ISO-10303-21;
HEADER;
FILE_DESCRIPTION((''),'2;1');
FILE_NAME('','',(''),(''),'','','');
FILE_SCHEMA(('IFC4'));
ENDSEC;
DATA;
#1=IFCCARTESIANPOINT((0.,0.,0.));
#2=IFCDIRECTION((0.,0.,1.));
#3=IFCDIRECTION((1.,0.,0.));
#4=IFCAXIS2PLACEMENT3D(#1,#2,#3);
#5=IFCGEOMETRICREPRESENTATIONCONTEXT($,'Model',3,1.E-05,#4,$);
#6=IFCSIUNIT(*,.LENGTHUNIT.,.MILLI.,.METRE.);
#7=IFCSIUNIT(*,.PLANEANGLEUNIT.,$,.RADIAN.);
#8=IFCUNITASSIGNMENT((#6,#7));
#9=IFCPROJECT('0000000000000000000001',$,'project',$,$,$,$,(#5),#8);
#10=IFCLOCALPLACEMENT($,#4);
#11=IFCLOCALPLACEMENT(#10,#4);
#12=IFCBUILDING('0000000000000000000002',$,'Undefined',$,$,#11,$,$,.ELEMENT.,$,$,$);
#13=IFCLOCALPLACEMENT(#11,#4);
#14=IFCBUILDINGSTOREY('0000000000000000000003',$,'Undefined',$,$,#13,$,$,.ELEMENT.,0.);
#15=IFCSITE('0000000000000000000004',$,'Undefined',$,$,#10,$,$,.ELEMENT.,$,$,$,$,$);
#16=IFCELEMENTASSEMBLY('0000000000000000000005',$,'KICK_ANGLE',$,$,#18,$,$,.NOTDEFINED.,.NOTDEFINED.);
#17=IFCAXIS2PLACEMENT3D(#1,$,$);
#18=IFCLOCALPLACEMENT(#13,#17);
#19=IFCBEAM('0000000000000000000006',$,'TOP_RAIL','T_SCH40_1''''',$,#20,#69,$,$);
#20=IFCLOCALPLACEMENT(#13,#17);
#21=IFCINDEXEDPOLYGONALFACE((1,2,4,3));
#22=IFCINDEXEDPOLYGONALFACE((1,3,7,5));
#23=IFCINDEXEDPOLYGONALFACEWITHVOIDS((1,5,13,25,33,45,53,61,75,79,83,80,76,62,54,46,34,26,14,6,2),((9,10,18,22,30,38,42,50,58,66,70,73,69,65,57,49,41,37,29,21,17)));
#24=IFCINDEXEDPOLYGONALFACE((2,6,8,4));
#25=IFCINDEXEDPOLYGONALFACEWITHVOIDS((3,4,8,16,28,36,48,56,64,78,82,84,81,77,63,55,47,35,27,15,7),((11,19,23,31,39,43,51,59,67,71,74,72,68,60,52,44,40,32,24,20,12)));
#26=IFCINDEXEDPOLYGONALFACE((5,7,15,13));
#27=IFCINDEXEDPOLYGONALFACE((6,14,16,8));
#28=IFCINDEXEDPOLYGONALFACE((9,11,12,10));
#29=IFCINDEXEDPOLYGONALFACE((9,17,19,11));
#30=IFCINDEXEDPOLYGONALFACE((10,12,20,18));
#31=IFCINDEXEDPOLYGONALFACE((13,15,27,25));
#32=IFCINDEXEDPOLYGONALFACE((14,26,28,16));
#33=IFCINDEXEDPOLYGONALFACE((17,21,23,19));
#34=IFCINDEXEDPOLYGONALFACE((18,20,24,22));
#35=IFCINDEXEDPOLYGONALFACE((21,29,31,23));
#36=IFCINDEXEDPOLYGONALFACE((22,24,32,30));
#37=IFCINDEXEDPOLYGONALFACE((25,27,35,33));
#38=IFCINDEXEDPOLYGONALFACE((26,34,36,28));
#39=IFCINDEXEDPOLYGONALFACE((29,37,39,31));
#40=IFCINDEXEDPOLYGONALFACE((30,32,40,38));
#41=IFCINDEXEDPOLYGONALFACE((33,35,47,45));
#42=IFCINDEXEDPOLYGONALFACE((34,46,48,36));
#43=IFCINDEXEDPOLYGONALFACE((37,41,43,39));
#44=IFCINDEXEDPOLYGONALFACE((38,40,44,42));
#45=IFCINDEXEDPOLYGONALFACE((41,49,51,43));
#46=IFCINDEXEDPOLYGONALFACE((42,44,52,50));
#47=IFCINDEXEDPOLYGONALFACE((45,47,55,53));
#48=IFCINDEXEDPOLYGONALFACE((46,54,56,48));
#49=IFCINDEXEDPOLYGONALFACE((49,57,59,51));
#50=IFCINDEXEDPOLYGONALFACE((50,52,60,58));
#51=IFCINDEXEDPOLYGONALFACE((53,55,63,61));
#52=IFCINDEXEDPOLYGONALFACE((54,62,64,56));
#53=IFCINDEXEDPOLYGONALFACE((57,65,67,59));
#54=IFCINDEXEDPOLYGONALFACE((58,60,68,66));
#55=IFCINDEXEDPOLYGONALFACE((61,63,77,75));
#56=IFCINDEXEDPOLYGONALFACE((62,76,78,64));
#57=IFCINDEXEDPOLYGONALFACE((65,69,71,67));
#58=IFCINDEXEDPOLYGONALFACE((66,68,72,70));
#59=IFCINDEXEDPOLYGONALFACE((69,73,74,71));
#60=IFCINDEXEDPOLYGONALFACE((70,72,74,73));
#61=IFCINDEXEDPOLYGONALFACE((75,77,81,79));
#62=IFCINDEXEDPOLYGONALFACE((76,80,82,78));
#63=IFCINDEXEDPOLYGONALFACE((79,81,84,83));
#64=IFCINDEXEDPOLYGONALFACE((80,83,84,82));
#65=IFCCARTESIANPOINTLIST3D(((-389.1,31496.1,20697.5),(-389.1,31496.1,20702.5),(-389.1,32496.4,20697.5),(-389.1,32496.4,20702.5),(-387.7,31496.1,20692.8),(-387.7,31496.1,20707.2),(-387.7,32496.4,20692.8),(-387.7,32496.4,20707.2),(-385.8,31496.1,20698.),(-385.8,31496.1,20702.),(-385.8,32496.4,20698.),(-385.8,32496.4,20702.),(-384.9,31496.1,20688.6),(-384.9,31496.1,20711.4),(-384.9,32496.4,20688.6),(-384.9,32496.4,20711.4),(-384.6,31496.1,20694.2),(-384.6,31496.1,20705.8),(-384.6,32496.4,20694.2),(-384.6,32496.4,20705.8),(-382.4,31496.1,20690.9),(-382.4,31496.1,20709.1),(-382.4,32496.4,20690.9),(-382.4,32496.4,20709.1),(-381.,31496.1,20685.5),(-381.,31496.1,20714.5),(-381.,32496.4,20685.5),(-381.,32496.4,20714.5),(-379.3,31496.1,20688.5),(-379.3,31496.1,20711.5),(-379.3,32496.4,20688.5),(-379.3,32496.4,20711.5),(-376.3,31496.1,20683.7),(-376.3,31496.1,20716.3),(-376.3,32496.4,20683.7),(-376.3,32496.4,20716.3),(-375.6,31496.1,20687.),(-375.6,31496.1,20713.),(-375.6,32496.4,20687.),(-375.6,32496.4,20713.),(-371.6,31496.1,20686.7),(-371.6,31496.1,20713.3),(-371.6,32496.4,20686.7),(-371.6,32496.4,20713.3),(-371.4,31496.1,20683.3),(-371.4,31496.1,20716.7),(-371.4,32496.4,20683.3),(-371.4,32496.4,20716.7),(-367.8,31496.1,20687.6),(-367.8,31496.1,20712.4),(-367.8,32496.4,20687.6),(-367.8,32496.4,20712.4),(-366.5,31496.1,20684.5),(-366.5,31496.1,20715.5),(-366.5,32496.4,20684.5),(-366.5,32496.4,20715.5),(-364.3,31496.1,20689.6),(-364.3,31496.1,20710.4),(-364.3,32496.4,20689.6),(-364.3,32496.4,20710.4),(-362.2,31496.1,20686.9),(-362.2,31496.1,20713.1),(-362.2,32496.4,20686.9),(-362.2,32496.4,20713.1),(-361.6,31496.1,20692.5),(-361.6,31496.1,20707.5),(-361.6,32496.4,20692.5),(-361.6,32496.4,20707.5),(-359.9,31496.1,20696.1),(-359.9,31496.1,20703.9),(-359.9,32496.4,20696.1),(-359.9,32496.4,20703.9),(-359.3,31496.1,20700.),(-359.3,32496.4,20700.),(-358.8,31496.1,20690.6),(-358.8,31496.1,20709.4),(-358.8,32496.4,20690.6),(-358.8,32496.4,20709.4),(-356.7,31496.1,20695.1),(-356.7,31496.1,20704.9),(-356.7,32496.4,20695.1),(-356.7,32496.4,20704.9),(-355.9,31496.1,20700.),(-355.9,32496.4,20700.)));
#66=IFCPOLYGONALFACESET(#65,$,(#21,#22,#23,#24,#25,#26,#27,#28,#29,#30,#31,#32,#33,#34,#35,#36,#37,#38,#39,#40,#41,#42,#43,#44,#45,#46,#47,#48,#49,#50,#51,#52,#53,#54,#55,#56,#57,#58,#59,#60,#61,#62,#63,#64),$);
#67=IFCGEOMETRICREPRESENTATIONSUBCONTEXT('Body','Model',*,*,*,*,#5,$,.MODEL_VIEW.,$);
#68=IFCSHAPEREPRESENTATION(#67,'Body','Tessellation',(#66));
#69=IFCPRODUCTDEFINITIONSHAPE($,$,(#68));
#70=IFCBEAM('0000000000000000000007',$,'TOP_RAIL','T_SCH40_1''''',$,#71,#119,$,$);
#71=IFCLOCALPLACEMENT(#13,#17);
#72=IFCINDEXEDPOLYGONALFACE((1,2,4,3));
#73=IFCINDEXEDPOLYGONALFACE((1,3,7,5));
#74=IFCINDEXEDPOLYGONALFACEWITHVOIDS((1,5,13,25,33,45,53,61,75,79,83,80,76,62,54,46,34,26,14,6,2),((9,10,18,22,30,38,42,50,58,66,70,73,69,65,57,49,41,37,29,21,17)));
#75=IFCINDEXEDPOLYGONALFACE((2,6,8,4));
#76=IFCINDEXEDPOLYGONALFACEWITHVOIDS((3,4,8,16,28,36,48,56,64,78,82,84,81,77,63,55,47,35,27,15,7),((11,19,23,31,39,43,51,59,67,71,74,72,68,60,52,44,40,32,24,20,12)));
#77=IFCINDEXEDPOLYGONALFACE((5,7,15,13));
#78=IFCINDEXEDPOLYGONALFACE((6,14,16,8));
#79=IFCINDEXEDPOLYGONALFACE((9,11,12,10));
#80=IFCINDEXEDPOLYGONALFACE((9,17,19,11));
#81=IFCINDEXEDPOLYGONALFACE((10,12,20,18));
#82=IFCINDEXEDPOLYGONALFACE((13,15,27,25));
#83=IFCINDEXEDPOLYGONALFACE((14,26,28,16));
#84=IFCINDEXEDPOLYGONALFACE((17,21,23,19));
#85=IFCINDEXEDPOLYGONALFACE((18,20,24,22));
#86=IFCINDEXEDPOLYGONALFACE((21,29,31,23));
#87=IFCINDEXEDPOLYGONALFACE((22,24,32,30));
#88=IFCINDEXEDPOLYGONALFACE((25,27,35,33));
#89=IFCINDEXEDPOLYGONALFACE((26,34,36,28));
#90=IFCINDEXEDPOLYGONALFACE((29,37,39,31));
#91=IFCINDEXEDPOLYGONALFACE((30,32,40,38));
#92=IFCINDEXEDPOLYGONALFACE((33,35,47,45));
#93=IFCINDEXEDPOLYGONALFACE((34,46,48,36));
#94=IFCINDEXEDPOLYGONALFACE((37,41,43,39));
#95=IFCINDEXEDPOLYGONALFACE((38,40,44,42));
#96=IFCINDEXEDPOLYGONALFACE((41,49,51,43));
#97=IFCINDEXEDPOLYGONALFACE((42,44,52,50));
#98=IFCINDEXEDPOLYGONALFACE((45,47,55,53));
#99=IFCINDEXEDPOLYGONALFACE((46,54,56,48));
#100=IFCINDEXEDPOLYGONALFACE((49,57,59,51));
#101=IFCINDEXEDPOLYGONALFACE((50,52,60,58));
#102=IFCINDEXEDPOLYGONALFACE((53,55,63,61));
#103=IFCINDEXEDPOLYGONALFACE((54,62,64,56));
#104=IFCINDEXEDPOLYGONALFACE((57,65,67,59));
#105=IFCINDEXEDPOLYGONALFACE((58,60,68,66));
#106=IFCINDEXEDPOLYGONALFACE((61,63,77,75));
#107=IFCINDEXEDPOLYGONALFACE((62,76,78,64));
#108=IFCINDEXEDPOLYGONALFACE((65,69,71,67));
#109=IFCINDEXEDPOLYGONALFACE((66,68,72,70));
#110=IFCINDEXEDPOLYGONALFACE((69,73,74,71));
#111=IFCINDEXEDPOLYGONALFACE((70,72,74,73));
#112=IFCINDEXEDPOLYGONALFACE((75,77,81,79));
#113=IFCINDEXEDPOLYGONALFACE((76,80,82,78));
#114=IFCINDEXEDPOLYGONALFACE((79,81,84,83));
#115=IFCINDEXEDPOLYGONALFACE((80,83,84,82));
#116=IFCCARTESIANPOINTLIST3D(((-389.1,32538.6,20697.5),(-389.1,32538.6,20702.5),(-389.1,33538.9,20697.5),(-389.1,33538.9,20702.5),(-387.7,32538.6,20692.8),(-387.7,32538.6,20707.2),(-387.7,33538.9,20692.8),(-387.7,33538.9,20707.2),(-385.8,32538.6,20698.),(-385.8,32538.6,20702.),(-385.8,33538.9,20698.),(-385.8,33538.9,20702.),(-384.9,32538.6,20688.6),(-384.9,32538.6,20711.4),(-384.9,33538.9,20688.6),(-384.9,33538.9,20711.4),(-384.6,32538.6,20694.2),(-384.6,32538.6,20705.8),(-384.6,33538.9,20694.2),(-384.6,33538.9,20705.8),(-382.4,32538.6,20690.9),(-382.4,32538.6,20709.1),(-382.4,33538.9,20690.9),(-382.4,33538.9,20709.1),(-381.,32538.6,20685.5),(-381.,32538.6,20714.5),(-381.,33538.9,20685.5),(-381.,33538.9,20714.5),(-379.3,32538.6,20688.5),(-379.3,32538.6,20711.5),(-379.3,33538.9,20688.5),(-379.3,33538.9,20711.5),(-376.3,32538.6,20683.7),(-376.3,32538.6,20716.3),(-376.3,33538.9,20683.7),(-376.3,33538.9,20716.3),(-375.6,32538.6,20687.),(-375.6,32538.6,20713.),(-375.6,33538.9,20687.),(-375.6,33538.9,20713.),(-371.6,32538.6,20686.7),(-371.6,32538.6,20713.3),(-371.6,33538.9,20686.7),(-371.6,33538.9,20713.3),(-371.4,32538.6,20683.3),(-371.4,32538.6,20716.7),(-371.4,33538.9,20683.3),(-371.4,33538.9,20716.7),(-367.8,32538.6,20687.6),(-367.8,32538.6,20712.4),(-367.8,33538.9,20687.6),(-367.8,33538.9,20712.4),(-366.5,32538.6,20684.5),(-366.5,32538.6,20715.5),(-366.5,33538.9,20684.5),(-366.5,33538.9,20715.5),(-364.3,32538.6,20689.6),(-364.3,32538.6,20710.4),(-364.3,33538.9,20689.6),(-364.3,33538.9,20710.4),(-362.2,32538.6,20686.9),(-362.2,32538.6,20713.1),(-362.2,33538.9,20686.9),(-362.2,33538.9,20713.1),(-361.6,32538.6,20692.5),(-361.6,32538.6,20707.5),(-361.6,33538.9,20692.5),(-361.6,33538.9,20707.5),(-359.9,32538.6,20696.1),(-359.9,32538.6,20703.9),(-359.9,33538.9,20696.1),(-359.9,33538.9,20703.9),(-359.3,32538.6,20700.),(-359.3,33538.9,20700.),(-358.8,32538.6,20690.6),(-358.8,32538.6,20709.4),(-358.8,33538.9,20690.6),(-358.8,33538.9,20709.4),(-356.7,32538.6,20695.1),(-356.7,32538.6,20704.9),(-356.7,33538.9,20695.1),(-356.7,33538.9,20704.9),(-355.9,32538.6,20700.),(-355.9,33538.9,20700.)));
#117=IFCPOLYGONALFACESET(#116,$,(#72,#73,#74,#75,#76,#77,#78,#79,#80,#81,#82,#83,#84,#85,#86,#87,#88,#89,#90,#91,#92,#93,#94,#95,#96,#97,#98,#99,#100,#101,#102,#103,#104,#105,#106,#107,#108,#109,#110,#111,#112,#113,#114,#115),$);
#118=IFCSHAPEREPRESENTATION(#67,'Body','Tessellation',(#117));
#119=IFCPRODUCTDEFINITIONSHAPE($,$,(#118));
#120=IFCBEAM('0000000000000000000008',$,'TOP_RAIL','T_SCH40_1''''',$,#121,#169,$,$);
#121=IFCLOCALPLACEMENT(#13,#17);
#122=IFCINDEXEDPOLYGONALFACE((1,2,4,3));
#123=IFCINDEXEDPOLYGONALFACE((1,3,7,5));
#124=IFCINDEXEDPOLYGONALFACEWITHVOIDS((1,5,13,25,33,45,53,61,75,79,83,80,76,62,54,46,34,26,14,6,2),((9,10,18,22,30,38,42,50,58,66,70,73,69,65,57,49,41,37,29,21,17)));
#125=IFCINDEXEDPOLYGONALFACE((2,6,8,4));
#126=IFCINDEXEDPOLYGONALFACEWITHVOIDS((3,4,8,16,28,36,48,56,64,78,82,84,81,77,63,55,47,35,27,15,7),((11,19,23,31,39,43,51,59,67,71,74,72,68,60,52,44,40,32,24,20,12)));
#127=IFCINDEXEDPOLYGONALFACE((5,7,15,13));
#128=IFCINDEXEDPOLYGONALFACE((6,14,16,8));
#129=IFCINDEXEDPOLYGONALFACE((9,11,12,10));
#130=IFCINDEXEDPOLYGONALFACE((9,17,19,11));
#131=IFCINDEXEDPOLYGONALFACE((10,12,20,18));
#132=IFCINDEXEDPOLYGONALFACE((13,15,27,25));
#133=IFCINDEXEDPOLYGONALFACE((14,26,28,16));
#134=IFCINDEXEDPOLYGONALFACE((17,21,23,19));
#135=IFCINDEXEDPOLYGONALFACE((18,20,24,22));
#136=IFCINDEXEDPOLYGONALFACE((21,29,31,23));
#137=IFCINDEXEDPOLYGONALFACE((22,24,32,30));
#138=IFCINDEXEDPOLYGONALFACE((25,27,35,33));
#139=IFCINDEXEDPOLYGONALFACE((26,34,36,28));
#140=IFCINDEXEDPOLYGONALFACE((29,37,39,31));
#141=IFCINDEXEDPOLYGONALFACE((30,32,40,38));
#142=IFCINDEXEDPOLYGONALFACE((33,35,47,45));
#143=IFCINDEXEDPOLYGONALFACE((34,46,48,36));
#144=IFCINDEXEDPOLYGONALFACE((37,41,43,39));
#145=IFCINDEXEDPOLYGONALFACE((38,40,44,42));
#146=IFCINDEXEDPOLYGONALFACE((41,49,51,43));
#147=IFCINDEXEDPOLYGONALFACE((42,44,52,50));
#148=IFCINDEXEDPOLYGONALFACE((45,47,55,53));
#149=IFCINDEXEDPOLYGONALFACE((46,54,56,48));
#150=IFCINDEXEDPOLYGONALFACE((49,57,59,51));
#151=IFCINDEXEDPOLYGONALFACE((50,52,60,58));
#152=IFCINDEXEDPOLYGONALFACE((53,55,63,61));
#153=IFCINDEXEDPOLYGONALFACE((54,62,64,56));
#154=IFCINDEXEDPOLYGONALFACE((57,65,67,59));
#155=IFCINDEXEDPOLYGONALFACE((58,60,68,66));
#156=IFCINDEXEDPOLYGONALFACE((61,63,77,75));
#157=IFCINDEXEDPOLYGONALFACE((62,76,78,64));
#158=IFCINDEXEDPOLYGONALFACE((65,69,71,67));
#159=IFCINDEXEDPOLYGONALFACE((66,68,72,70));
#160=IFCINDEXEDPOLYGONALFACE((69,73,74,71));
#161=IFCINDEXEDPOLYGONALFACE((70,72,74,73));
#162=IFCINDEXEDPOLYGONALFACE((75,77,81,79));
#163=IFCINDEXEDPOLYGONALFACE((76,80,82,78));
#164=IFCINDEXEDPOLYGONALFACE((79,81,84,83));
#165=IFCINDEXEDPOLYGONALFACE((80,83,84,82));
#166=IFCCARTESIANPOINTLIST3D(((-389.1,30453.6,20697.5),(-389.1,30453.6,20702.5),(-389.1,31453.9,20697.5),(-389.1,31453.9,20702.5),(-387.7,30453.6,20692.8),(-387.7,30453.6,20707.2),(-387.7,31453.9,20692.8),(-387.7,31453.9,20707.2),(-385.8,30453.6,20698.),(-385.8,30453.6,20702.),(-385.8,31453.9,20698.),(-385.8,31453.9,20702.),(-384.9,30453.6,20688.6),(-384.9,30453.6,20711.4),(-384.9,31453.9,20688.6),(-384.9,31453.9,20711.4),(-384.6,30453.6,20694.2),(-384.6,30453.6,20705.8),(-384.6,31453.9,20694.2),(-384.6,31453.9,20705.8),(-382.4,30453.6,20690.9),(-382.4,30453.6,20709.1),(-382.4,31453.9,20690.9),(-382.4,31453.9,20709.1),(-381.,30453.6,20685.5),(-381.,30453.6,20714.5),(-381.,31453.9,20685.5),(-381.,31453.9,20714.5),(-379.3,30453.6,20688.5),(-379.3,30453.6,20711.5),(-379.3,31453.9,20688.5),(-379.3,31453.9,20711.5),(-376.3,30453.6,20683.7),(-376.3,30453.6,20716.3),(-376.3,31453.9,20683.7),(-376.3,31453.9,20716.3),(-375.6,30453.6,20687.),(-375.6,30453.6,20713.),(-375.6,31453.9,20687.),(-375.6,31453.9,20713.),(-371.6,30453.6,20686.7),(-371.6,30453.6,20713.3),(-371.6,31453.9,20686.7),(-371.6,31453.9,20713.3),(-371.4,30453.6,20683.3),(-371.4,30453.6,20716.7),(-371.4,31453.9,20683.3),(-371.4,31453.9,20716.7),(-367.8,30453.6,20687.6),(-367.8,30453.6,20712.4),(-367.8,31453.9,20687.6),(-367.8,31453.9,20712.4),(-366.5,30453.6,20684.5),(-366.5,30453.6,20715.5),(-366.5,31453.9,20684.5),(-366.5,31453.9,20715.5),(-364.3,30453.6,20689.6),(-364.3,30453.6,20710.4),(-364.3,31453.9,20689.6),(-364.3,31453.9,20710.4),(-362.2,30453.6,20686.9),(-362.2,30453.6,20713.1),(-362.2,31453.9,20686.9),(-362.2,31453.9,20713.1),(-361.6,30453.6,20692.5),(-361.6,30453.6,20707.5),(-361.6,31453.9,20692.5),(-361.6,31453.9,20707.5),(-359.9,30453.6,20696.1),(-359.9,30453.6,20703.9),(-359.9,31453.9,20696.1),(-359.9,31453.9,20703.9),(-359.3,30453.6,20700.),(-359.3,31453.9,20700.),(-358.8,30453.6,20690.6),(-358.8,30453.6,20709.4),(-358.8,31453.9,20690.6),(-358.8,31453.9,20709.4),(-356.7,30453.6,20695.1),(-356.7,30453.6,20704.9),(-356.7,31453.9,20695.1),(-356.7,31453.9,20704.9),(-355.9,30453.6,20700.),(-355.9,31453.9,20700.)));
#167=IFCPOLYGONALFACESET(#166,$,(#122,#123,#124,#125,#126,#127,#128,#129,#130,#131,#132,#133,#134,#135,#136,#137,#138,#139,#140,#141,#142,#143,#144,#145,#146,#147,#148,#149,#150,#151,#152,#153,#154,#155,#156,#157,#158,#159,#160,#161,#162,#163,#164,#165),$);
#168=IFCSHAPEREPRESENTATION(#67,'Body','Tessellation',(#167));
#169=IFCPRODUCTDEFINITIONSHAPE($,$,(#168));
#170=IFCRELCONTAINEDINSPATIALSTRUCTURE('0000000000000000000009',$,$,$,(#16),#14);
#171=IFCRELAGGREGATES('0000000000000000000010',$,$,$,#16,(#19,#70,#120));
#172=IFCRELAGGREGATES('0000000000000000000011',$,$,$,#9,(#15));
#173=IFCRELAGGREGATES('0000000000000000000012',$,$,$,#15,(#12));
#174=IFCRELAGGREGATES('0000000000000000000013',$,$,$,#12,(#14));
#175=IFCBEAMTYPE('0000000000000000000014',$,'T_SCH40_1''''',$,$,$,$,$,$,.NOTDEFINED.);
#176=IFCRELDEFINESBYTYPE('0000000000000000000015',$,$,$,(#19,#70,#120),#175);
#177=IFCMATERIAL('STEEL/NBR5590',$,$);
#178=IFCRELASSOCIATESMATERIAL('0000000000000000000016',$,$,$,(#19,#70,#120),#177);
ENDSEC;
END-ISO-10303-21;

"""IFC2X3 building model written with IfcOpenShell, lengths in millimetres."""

from ifc_helpers import new_model, si_unit, frame, origin_with_axes, origin_2d_with_axis, place, context, subcontext, project, spatial, hollow_circle, extrude, material, type_object, element, aggregate, save


model = new_model("IFC2X3")

# Units and contexts
model_context = context("Model", 3, precision=1e-05, world=origin_with_axes())
body_context = subcontext(model_context, "Body", "Model", "MODEL_VIEW")
ifc_project = project(units=[si_unit("LENGTHUNIT", "METRE", prefix="MILLI"), si_unit("PLANEANGLEUNIT", "RADIAN")], contexts=[model_context])

# Site, building, storey
site_placement = place(None, origin_with_axes())
site = spatial("IfcSite", under=ifc_project, at=site_placement, Name="Undefined", CompositionType="ELEMENT")
building_placement = place(site_placement, origin_with_axes())
building = spatial("IfcBuilding", under=site, at=building_placement, Name="Undefined", CompositionType="ELEMENT")
storey_placement = place(building_placement, origin_with_axes())
storey = spatial("IfcBuildingStorey", under=building, at=storey_placement, Name="Undefined", CompositionType="ELEMENT", Elevation=0.0)

# Shared definitions
ifc_material_1 = material(Name="STEEL/NBR5590")

# Element assembly
assembly_1_placement = place(storey_placement, origin_with_axes())
assembly_1 = element("IfcElementAssembly", 1, at=assembly_1_placement, inside=storey, Name="KICK_ANGLE", AssemblyPlace="NOTDEFINED", PredefinedType="NOTDEFINED")

# Beams
beam_type_1 = type_object("IfcBeamType", Name="T_SCH40_1''", PredefinedType="NOTDEFINED")
beam_1_placement = place(assembly_1_placement, frame((-372.6, 31496.1, 20700.0), z_axis=(0.0, 0.0, 1.0), x_axis=(0.0, 1.0, 0.0)))
beam_1 = element("IfcBeam", 2, at=beam_1_placement, type_object=beam_type_1, material=ifc_material_1, Name="TOP_RAIL", Description="T_SCH40_1''", context=body_context, shape_type="SweptSolid", body=[
    extrude(hollow_circle(Radius=16.7, WallThickness=3.4, at=origin_2d_with_axis()), frame((1000.3, 0.0, 0.0), z_axis=(-1.0, 0.0, 0.0), x_axis=(0.0, -1.0, 0.0)), (0.0, 0.0, 1.0), 1000.3),
])
beam_2_placement = place(assembly_1_placement, frame((-372.6, 32538.6, 20700.0), z_axis=(0.0, 0.0, 1.0), x_axis=(0.0, 1.0, 0.0)))
beam_2 = element("IfcBeam", 3, at=beam_2_placement, type_object=beam_type_1, material=ifc_material_1, Name="TOP_RAIL", Description="T_SCH40_1''", context=body_context, shape_type="SweptSolid", body=[
    extrude(hollow_circle(Radius=16.7, WallThickness=3.4, at=origin_2d_with_axis()), frame((1000.3, 0.0, 0.0), z_axis=(-1.0, 0.0, 0.0), x_axis=(0.0, -1.0, 0.0)), (0.0, 0.0, 1.0), 1000.3),
])
beam_3_placement = place(assembly_1_placement, frame((-372.6, 30453.6, 20700.0), z_axis=(0.0, 0.0, 1.0), x_axis=(0.0, 1.0, 0.0)))
beam_3 = element("IfcBeam", 4, at=beam_3_placement, type_object=beam_type_1, material=ifc_material_1, Name="TOP_RAIL", Description="T_SCH40_1''", context=body_context, shape_type="SweptSolid", body=[
    extrude(hollow_circle(Radius=16.7, WallThickness=3.4, at=origin_2d_with_axis()), frame((1000.3, 0.0, 0.0), z_axis=(-1.0, 0.0, 0.0), x_axis=(0.0, -1.0, 0.0)), (0.0, 0.0, 1.0), 1000.3),
])

aggregate(assembly_1, [beam_1, beam_2, beam_3])

save(model, "model.ifc")
